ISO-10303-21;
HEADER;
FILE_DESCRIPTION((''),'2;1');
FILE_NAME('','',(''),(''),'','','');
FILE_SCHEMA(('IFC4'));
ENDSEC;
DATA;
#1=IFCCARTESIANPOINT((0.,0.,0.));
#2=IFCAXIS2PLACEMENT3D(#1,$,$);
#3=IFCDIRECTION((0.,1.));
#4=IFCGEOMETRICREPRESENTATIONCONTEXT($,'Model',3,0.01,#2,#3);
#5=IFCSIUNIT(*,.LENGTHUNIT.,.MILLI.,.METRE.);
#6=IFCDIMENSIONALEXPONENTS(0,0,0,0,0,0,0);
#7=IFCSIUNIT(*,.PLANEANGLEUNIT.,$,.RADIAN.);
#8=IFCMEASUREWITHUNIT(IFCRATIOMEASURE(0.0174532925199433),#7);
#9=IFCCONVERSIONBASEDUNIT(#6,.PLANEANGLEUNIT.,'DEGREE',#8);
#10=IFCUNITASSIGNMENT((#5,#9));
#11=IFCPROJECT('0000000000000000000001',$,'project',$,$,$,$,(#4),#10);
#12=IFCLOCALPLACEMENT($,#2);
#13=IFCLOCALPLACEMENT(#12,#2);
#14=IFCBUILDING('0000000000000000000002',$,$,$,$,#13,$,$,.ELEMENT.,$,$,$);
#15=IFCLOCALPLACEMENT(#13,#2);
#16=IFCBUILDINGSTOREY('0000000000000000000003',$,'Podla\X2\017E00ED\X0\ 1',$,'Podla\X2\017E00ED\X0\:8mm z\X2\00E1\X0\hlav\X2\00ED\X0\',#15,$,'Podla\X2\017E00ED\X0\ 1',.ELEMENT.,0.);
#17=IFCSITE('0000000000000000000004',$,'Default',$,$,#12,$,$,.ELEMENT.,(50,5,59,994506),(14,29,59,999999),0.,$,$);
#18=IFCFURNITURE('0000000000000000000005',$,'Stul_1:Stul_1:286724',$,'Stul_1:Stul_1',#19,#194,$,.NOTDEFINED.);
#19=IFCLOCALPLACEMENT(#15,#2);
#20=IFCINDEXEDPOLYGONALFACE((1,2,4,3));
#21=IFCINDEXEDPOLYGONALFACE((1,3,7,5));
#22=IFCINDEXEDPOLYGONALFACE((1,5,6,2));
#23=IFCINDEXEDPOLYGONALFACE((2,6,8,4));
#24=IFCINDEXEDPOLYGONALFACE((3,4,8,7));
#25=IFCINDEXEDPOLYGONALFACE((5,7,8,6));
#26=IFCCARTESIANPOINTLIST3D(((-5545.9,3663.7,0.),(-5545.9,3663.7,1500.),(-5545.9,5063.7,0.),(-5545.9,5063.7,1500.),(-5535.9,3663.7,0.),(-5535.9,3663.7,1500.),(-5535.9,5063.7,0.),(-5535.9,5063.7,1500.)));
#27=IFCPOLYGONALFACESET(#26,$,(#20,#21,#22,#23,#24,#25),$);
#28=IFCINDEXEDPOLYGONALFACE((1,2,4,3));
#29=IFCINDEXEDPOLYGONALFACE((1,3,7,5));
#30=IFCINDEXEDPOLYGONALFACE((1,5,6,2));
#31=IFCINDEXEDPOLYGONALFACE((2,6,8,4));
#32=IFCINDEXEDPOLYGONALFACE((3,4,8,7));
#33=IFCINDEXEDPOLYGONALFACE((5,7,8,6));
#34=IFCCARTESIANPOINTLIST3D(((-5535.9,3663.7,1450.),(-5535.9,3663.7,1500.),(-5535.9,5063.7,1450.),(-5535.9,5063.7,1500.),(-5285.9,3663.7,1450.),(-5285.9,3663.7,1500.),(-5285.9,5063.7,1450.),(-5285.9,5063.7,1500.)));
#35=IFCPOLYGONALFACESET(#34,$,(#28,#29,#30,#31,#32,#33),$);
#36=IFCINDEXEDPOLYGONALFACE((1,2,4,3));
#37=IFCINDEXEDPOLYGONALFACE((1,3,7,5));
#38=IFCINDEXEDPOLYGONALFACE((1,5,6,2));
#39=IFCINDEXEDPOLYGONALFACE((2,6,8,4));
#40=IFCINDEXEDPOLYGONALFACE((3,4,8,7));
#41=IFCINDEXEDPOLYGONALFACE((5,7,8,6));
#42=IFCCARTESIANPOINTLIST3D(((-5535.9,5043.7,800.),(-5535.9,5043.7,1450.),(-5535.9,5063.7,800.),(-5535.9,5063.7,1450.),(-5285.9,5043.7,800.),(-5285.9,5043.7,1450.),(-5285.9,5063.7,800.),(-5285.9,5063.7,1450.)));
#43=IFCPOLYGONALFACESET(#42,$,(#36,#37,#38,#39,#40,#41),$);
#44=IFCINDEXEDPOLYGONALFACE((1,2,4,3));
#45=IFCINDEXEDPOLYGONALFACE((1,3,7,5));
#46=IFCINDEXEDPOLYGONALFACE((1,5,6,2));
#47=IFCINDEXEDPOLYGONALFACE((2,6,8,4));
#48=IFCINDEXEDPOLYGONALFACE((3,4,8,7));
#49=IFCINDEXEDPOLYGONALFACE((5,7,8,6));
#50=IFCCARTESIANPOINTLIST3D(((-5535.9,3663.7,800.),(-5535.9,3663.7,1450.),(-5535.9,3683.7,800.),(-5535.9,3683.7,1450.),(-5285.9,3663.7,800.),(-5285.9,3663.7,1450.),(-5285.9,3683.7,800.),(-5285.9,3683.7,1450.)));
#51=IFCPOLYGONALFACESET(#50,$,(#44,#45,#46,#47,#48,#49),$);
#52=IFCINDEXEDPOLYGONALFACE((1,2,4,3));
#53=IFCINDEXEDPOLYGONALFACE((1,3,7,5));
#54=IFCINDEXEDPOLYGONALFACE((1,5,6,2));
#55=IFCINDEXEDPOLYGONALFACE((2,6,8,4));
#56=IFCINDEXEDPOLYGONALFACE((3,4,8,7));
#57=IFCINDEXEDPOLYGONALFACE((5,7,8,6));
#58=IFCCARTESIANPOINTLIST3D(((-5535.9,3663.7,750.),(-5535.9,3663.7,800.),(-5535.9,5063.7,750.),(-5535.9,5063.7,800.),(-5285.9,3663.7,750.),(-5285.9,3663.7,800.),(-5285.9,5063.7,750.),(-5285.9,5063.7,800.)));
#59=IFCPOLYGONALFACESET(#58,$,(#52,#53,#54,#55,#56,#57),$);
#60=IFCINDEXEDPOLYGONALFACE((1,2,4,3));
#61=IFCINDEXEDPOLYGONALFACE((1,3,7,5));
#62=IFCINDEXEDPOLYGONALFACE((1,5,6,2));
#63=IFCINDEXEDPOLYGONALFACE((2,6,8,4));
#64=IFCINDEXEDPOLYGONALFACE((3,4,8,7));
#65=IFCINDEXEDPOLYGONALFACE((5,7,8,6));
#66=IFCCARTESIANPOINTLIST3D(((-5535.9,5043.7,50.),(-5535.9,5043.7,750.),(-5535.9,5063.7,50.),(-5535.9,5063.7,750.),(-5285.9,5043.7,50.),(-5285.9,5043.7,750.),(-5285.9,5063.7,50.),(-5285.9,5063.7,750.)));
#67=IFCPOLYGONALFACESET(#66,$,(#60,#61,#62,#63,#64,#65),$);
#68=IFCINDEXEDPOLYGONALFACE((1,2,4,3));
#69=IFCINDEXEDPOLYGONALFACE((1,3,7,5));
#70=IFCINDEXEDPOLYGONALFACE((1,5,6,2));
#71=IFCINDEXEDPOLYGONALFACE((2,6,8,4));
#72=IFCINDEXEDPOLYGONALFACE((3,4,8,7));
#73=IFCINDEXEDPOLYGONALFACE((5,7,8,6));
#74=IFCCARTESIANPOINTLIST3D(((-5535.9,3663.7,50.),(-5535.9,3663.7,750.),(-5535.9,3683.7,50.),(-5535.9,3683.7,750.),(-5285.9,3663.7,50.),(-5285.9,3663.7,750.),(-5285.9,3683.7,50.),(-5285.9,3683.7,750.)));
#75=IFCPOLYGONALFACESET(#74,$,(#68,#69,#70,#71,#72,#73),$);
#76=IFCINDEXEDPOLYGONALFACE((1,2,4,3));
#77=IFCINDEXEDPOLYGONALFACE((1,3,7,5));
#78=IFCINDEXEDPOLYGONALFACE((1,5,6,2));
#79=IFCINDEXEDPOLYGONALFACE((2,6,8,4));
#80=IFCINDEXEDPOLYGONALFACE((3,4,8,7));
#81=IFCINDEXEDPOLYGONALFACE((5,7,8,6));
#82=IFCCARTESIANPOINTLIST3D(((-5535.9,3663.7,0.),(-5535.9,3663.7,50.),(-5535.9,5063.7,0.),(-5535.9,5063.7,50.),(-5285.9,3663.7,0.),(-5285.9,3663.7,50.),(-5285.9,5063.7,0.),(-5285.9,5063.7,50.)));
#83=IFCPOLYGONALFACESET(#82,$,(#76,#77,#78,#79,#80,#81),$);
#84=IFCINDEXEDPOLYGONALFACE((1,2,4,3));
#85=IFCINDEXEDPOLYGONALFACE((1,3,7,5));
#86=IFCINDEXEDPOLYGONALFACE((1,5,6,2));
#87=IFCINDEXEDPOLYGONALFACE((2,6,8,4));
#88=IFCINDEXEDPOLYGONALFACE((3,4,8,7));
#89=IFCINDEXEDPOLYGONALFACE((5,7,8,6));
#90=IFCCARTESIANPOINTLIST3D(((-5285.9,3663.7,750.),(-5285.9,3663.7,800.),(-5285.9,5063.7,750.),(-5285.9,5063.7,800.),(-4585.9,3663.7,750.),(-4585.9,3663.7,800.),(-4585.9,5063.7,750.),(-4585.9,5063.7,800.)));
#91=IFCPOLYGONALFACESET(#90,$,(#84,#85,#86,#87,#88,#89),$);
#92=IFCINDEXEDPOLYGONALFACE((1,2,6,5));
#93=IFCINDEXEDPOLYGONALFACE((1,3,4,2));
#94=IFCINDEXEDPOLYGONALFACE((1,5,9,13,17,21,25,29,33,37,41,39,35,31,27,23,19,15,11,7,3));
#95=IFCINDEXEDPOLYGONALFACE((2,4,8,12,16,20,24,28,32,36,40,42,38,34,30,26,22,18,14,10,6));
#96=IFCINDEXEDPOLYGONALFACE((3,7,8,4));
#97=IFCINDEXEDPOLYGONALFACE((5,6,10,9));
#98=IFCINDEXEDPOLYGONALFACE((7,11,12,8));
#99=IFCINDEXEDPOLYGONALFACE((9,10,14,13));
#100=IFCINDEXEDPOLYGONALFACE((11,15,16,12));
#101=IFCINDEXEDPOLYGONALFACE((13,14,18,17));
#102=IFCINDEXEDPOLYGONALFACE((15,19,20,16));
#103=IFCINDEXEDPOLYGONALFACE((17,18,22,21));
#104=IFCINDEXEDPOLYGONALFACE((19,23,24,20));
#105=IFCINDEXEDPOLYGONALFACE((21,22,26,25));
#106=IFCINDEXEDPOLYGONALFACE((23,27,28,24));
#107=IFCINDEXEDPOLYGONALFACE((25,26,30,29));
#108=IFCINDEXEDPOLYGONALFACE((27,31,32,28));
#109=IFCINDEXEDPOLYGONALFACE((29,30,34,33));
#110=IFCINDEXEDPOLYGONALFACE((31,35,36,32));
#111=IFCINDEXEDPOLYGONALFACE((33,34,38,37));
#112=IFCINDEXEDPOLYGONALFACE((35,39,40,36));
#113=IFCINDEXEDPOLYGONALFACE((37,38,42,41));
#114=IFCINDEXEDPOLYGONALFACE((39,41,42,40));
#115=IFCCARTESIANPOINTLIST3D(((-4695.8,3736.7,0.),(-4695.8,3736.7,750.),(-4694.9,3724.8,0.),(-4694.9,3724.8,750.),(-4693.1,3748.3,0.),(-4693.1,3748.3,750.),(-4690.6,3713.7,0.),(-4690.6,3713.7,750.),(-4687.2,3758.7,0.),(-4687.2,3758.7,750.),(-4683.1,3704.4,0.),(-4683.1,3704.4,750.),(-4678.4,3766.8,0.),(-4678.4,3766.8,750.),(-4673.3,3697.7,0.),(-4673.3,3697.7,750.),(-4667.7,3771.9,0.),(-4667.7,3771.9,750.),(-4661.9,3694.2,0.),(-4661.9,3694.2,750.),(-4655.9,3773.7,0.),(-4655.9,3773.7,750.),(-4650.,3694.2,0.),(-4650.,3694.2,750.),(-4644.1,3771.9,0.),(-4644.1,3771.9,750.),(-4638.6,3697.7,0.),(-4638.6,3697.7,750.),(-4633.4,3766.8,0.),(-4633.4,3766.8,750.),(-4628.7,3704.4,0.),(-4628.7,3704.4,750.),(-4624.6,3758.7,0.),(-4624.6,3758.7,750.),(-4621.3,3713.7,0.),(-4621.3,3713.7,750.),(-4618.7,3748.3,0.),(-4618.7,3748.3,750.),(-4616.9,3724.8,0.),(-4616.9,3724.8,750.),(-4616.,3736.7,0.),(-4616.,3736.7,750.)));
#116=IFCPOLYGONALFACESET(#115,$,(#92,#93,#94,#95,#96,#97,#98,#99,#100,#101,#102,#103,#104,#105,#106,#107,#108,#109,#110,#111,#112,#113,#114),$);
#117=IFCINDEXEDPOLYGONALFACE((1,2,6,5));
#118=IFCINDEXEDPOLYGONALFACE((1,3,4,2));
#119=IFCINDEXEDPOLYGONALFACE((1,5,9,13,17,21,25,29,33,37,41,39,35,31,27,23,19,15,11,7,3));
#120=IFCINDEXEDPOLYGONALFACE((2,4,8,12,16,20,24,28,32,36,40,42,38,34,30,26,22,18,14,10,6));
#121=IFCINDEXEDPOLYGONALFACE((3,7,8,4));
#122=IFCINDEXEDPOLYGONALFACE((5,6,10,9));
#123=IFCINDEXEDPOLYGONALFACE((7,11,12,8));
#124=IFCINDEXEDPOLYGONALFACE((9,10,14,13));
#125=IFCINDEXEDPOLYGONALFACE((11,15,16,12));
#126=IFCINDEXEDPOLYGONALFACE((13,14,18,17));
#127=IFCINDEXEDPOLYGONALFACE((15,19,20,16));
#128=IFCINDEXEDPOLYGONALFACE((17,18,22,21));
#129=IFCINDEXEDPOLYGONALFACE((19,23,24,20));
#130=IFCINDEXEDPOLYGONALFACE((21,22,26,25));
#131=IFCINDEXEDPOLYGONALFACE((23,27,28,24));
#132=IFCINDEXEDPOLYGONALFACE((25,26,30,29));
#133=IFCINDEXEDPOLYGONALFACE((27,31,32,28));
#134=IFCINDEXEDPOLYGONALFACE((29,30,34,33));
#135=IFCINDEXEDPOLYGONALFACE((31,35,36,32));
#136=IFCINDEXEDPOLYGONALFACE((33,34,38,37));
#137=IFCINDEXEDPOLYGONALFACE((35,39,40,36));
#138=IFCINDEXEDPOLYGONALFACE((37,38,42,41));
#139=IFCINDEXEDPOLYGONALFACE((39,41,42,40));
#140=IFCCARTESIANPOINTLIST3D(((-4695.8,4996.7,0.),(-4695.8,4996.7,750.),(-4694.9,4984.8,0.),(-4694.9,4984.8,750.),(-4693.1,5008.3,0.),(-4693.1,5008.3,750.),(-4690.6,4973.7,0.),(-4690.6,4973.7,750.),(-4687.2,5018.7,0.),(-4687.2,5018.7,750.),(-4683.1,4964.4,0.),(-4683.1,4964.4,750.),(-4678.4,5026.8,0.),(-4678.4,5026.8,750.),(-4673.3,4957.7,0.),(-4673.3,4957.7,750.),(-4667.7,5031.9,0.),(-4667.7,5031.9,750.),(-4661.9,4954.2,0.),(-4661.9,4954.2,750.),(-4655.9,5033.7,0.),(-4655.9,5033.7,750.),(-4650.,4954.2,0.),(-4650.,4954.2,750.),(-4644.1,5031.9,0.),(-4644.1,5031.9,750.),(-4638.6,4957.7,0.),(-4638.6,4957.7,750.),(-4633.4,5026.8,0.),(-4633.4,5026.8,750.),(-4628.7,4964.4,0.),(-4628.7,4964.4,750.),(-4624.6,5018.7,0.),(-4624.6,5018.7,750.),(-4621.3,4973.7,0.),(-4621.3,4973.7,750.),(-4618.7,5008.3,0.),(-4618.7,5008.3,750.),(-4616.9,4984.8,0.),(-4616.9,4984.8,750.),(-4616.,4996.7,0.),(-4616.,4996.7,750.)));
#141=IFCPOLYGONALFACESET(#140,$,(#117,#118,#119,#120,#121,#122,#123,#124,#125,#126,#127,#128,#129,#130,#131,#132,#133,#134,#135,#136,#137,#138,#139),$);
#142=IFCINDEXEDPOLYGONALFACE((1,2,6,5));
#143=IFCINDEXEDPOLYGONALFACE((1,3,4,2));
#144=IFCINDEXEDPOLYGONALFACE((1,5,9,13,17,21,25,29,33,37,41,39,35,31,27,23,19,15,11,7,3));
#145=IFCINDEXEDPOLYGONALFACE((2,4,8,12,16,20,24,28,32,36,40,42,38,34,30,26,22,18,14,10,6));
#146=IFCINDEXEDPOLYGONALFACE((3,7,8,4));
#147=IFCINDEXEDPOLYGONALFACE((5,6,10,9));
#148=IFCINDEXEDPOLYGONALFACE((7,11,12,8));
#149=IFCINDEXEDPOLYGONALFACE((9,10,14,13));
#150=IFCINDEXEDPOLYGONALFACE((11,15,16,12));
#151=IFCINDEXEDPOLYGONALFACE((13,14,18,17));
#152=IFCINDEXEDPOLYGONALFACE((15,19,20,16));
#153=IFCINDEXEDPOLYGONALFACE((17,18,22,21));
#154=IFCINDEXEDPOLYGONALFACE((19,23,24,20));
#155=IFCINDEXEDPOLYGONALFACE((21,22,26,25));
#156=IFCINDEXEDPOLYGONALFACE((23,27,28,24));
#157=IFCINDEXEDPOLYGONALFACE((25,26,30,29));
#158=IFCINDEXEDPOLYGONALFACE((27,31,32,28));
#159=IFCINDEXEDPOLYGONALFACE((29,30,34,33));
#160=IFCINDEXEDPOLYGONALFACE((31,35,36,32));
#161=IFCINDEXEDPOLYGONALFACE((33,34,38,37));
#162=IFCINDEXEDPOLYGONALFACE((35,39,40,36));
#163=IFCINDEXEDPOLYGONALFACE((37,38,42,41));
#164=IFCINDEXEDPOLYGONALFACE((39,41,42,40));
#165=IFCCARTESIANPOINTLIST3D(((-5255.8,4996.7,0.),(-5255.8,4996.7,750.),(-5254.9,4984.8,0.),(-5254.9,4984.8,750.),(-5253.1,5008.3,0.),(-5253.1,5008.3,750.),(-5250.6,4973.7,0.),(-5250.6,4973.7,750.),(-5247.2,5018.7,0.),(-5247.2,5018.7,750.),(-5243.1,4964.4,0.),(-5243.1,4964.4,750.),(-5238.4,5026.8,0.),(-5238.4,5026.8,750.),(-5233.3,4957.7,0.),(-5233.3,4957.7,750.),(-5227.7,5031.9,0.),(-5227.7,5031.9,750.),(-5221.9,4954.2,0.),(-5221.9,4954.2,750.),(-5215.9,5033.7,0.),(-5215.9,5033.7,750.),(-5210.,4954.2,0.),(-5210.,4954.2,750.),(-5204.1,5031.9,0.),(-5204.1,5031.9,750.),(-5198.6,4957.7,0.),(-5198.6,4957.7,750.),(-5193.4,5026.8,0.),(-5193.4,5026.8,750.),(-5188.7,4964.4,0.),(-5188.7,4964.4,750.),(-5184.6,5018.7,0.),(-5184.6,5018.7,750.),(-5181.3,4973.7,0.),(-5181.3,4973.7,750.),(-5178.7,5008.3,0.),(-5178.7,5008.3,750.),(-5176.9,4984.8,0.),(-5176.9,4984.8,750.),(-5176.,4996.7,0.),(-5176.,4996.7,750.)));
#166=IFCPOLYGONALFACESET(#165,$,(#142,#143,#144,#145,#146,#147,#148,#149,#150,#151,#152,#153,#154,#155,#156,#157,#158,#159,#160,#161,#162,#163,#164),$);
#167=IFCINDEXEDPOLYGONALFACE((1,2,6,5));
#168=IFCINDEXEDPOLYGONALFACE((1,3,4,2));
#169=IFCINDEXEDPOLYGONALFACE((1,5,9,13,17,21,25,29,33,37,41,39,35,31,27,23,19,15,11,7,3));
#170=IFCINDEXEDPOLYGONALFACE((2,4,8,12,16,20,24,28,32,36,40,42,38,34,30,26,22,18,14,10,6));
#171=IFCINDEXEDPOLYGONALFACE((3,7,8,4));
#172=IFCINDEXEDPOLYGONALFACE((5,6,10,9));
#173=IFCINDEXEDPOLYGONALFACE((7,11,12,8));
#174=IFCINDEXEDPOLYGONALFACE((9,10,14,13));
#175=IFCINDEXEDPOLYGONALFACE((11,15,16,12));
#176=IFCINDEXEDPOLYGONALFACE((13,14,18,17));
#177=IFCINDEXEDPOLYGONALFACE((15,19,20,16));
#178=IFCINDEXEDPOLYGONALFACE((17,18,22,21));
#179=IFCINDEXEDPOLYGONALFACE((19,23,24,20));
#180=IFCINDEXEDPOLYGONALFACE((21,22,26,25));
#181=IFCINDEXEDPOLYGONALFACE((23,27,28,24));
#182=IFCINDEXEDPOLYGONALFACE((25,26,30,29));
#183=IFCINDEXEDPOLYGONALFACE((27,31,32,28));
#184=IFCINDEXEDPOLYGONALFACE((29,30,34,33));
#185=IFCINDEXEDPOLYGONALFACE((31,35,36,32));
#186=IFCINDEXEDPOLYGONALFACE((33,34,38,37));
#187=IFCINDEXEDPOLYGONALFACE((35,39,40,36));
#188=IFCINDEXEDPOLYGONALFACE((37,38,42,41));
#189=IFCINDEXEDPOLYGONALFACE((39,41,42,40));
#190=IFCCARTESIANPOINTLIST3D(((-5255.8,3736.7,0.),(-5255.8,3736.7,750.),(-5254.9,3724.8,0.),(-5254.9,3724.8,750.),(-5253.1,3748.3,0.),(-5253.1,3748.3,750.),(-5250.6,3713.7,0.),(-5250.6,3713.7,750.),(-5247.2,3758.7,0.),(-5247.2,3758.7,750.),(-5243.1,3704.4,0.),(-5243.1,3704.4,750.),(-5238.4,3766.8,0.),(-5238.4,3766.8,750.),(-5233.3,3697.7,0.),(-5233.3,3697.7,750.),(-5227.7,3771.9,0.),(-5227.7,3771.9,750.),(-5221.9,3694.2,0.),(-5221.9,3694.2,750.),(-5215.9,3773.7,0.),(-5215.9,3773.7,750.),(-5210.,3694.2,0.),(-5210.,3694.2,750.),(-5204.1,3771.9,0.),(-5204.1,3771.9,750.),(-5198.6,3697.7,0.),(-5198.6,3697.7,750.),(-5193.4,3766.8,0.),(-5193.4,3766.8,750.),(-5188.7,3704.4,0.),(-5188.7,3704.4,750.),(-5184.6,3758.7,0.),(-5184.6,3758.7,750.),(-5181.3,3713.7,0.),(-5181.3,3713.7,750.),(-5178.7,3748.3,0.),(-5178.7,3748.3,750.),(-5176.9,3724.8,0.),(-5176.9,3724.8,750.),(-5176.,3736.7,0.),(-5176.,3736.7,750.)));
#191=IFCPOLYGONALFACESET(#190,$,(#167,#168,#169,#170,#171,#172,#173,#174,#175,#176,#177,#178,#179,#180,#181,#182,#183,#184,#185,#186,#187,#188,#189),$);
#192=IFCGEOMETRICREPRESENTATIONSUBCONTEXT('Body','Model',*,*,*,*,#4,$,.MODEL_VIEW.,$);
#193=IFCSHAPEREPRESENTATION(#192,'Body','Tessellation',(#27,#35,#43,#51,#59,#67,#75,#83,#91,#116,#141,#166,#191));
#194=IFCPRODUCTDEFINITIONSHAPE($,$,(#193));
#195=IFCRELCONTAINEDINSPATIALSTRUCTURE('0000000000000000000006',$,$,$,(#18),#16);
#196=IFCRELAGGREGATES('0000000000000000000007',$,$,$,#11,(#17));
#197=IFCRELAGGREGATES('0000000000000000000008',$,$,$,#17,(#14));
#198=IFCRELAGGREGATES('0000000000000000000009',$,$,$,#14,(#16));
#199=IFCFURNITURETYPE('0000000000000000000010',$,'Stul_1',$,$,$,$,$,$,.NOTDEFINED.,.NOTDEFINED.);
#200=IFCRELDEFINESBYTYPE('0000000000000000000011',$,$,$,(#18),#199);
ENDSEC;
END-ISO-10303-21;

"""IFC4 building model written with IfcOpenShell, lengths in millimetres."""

from ifc_helpers import new_model, entity, si_unit, converted_unit, direction, frame, frame_2d, origin, origin_2d_with_axis, place, context, subcontext, project, spatial, rectangle, circle, extrude, source, transform, mapped, type_object, type_shapes, element, save


model = new_model("IFC4")

# Units and contexts
model_context = context("Model", 3, precision=0.01, world=origin(), true_north=direction((0.0, 1.0)))
body_context = subcontext(model_context, "Body", "Model", "MODEL_VIEW")
ifc_project = project(units=[si_unit("LENGTHUNIT", "METRE", prefix="MILLI"), converted_unit("PLANEANGLEUNIT", "DEGREE", entity("IfcRatioMeasure", 0.0174532925199433), si_unit("PLANEANGLEUNIT", "RADIAN"), dimensions=[0, 0, 0, 0, 0, 0, 0])], contexts=[model_context])

# Site, building, storey
site_placement = place(None, origin())
site = spatial("IfcSite", under=ifc_project, at=site_placement, Name="Default", CompositionType="ELEMENT", RefLatitude=(50, 5, 59, 994506), RefLongitude=(14, 29, 59, 999999), RefElevation=0.0)
building_placement = place(site_placement, origin())
building = spatial("IfcBuilding", under=site, at=building_placement, CompositionType="ELEMENT")
storey_placement = place(building_placement, origin())
storey = spatial("IfcBuildingStorey", under=building, at=storey_placement, Name="Podlaží 1", ObjectType="Podlaží:8mm záhlaví", LongName="Podlaží 1", CompositionType="ELEMENT", Elevation=0.0)

# Furniture
furniture_type = type_object("IfcFurnitureType", Name="Stul_1", AssemblyPlace="NOTDEFINED", PredefinedType="NOTDEFINED")
shared_shape_1 = source(origin(), body_context, "Body", "SweptSolid", [
    extrude(rectangle(XDim=1400.0, YDim=10.0, at=origin_2d_with_axis()), frame((0.0, 605.0, 0.0), z_axis=(0.0, 0.0, 1.0), x_axis=(-1.0, 0.0, 0.0)), (0.0, 0.0, 1.0), 1500.0),
    extrude(rectangle(XDim=1400.0, YDim=250.0, at=frame_2d((0.0, 0.0), x_axis=(1.0, 0.0))), frame((0.0, 475.0, 1450.0), z_axis=(0.0, 0.0, 1.0), x_axis=(-1.0, 0.0, 0.0)), (0.0, 0.0, 1.0), 50.0),
    extrude(rectangle(XDim=20.0, YDim=250.0, at=origin_2d_with_axis()), frame((690.0, 475.0, 800.0), z_axis=(0.0, 0.0, 1.0), x_axis=(-1.0, 0.0, 0.0)), (0.0, 0.0, 1.0), 650.0),
    extrude(rectangle(XDim=20.0, YDim=250.0, at=frame_2d((0.0, 0.0), x_axis=(1.0, 0.0))), frame((-690.0, 475.0, 800.0), z_axis=(0.0, 0.0, 1.0), x_axis=(-1.0, 0.0, 0.0)), (0.0, 0.0, 1.0), 650.0),
    extrude(rectangle(XDim=1400.0, YDim=250.0, at=origin_2d_with_axis()), frame((0.0, 475.0, 750.0), z_axis=(0.0, 0.0, 1.0), x_axis=(-1.0, 0.0, 0.0)), (0.0, 0.0, 1.0), 50.0),
    extrude(rectangle(XDim=20.0, YDim=250.0, at=origin_2d_with_axis()), frame((690.0, 475.0, 50.0), z_axis=(0.0, 0.0, 1.0), x_axis=(-1.0, 0.0, 0.0)), (0.0, 0.0, 1.0), 700.0),
    extrude(rectangle(XDim=20.0, YDim=250.0, at=frame_2d((0.0, 0.0), x_axis=(1.0, 0.0))), frame((-690.0, 475.0, 50.0), z_axis=(0.0, 0.0, 1.0), x_axis=(-1.0, 0.0, 0.0)), (0.0, 0.0, 1.0), 700.0),
    extrude(rectangle(XDim=1400.0, YDim=250.0, at=origin_2d_with_axis()), frame((0.0, 475.0, 0.0), z_axis=(0.0, 0.0, 1.0), x_axis=(-1.0, 0.0, 0.0)), (0.0, 0.0, 1.0), 50.0),
    extrude(rectangle(XDim=1400.0, YDim=700.0, at=origin_2d_with_axis()), frame((0.0, 0.0, 750.0), z_axis=(0.0, 0.0, 1.0), x_axis=(-1.0, 0.0, 0.0)), (0.0, 0.0, 1.0), 50.0),
    extrude(circle(Radius=40.0, at=frame_2d((0.0, 0.0), x_axis=(1.0, 0.0))), frame((-630.0, -280.0, 0.0)), (0.0, 0.0, 1.0), 750.0),
    extrude(circle(Radius=40.0, at=frame_2d((0.0, 0.0), x_axis=(1.0, 0.0))), frame((630.0, -280.0, 0.0)), (0.0, 0.0, 1.0), 750.0),
    extrude(circle(Radius=40.0, at=frame_2d((0.0, 0.0), x_axis=(1.0, 0.0))), frame((630.0, 280.0, 0.0)), (0.0, 0.0, 1.0), 750.0),
    extrude(circle(Radius=40.0, at=frame_2d((0.0, 0.0), x_axis=(1.0, 0.0))), frame((-630.0, 280.0, 0.0)), (0.0, 0.0, 1.0), 750.0),
])
type_shapes(furniture_type, [shared_shape_1])
for number, where, z_axis, x_axis, name in (
    (1, (-4935.9, 4363.7, 0.0), (0.0, 0.0, 1.0), (0.0, 1.0, 0.0), "Stul_1:Stul_1:286724"),
):
    element("IfcFurniture", number, at=place(storey_placement, frame(where, z_axis=z_axis, x_axis=x_axis)), inside=storey, type_object=furniture_type, Name=name, ObjectType="Stul_1:Stul_1", PredefinedType="NOTDEFINED", context=body_context, shape_type="MappedRepresentation", body=[
        mapped(shared_shape_1, transform((0.0, 0.0, 0.0), scale=1.0)),
    ])

save(model, "model.ifc")
